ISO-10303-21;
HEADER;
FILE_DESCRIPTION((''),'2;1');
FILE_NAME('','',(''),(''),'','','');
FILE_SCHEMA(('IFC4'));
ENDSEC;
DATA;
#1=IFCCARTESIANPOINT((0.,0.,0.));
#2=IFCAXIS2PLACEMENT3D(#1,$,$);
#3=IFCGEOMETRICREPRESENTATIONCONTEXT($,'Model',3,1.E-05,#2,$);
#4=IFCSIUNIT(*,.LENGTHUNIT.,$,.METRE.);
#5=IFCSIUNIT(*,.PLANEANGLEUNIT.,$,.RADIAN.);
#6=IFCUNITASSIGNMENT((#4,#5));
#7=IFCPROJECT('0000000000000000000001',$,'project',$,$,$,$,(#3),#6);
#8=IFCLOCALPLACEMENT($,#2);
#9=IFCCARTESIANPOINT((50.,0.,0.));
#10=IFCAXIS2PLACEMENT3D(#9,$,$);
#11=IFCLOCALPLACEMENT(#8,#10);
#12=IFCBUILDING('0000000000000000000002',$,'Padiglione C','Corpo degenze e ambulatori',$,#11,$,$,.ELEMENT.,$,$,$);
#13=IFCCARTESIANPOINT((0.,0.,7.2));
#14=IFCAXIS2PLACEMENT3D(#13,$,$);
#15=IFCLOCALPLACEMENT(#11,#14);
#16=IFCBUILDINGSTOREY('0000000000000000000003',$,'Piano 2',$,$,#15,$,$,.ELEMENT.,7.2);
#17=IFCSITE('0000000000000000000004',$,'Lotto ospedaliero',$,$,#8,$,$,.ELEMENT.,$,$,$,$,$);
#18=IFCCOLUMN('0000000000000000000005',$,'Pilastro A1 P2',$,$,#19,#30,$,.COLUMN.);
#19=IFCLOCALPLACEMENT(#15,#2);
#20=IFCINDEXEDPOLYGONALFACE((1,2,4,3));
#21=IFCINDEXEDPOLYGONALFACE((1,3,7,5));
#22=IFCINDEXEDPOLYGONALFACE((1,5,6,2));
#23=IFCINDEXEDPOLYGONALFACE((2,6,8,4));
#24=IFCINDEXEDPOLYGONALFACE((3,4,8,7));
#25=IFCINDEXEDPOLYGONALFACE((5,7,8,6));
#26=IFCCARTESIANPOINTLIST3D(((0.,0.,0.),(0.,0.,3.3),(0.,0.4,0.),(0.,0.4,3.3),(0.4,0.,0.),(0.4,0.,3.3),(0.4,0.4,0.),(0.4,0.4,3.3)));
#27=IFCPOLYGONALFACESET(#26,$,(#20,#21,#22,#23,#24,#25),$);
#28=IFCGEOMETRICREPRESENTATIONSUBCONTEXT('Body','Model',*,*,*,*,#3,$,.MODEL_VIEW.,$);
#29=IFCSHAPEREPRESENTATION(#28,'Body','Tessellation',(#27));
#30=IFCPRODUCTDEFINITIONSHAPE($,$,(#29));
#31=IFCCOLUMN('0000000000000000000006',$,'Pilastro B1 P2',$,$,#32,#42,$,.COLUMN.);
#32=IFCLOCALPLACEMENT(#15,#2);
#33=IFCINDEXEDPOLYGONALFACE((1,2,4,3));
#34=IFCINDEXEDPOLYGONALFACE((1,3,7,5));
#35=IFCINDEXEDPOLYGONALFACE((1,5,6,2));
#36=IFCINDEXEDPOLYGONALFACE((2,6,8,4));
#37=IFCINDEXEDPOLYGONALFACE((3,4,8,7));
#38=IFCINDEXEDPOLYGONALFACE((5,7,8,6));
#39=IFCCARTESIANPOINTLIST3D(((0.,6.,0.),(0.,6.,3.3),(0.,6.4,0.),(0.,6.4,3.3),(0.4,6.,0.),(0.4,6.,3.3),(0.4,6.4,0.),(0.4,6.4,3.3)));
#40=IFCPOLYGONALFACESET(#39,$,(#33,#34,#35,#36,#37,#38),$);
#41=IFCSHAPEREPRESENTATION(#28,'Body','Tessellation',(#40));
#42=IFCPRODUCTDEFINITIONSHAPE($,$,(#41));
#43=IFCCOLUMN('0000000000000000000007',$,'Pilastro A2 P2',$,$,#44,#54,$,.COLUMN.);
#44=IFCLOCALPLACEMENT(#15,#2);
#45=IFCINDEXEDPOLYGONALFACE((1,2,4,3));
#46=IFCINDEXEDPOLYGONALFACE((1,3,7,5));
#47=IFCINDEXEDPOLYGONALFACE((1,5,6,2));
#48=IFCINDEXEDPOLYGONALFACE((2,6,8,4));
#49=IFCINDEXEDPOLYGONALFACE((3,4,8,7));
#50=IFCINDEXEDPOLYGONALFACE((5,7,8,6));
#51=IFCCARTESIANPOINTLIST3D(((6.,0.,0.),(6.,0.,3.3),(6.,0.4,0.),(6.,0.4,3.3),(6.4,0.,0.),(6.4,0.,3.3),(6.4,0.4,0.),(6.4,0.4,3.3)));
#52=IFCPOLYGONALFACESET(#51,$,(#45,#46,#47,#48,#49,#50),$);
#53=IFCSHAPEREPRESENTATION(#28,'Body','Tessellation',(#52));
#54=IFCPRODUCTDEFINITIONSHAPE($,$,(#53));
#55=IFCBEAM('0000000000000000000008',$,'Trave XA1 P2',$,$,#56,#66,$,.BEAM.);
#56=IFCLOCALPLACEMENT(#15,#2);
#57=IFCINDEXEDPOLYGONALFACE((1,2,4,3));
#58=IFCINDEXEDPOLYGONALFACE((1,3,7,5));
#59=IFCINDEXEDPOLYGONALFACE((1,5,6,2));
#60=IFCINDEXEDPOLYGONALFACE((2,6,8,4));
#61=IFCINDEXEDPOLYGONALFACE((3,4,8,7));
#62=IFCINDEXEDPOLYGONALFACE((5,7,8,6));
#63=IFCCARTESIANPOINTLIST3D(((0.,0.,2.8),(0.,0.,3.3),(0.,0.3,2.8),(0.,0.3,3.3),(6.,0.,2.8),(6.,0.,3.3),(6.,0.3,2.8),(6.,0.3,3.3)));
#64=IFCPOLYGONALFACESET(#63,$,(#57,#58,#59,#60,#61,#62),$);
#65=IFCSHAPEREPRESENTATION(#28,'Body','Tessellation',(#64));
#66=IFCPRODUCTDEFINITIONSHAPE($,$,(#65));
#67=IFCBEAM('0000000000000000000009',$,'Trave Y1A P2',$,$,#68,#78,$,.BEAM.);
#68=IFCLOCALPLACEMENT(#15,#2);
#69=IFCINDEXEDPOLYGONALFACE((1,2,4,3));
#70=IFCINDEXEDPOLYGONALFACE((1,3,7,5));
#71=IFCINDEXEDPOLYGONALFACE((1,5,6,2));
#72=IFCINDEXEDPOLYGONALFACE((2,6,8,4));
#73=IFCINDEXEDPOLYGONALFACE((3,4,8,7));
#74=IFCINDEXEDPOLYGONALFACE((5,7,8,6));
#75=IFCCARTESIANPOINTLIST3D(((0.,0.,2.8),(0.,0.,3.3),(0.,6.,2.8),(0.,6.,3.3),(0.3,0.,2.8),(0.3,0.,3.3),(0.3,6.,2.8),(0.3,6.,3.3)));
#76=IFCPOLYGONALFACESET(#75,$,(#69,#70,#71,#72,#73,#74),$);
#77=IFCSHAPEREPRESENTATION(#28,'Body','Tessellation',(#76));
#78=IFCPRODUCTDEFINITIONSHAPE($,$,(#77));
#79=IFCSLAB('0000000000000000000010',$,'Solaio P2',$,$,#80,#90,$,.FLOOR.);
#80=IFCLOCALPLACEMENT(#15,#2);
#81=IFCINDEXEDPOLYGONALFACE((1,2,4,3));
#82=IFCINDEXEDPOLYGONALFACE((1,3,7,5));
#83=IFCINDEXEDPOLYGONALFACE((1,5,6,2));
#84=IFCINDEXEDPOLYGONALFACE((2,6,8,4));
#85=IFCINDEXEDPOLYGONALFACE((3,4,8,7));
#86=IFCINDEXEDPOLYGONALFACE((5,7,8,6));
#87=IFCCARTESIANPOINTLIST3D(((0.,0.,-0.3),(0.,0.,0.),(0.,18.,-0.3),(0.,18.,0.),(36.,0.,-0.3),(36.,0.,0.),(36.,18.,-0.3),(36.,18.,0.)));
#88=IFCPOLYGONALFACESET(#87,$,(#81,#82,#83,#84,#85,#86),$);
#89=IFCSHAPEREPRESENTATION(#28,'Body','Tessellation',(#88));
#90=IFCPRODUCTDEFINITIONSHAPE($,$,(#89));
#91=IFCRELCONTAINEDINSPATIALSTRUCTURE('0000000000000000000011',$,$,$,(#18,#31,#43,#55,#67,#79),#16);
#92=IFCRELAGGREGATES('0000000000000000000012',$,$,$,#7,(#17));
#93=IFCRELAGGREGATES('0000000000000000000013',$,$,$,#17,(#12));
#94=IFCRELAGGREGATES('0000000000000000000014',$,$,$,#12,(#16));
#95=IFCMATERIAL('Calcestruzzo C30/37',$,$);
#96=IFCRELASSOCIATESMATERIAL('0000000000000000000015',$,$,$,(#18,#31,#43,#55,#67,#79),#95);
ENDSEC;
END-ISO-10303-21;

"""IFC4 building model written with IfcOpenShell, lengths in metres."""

from ifc_helpers import new_model, si_unit, frame, frame_2d, origin, place, context, subcontext, project, spatial, rectangle, extrude, material, element, save


model = new_model("IFC4")

# Units and contexts
model_context = context("Model", 3, precision=1e-05, world=origin())
body_context = subcontext(model_context, "Body", "Model", "MODEL_VIEW")
ifc_project = project(units=[si_unit("LENGTHUNIT", "METRE"), si_unit("PLANEANGLEUNIT", "RADIAN")], contexts=[model_context])

# Site, building, storey
site_placement = place(None, origin())
site = spatial("IfcSite", under=ifc_project, at=site_placement, Name="Lotto ospedaliero", CompositionType="ELEMENT")
building_placement = place(site_placement, frame((50.0, 0.0, 0.0)))
building = spatial("IfcBuilding", under=site, at=building_placement, Name="Padiglione C", Description="Corpo degenze e ambulatori", CompositionType="ELEMENT")
storey_placement = place(building_placement, frame((0.0, 0.0, 7.2)))
storey = spatial("IfcBuildingStorey", under=building, at=storey_placement, Name="Piano 2", CompositionType="ELEMENT", Elevation=7.2)

# Columns
ifc_material_1 = material(Name="Calcestruzzo C30/37")
for number, where, name in (
    (1, (0.0, 0.0, 0.0), "Pilastro A1 P2"),
    (2, (0.0, 6.0, 0.0), "Pilastro B1 P2"),
    (3, (6.0, 0.0, 0.0), "Pilastro A2 P2"),
):
    element("IfcColumn", number, at=place(storey_placement, frame(where)), inside=storey, material=ifc_material_1, Name=name, PredefinedType="COLUMN", context=body_context, shape_type="SweptSolid", body=[
        extrude(rectangle(XDim=0.4, YDim=0.4, at=frame_2d((0.2, 0.2))), origin(), (0.0, 0.0, 1.0), 3.3),
    ])

# Beams
beam_1_placement = place(storey_placement, frame((0.0, 0.0, 2.8)))
element("IfcBeam", 4, at=beam_1_placement, inside=storey, material=ifc_material_1, Name="Trave XA1 P2", PredefinedType="BEAM", context=body_context, shape_type="SweptSolid", body=[
    extrude(rectangle(XDim=6.0, YDim=0.3, at=frame_2d((3.0, 0.15))), origin(), (0.0, 0.0, 1.0), 0.5),
])
beam_2_placement = place(storey_placement, frame((0.0, 0.0, 2.8)))
element("IfcBeam", 5, at=beam_2_placement, inside=storey, material=ifc_material_1, Name="Trave Y1A P2", PredefinedType="BEAM", context=body_context, shape_type="SweptSolid", body=[
    extrude(rectangle(XDim=0.3, YDim=6.0, at=frame_2d((0.15, 3.0))), origin(), (0.0, 0.0, 1.0), 0.5),
])

# Slab
slab_placement = place(storey_placement, frame((0.0, 0.0, -0.3)))
element("IfcSlab", 6, at=slab_placement, inside=storey, material=ifc_material_1, Name="Solaio P2", PredefinedType="FLOOR", context=body_context, shape_type="SweptSolid", body=[
    extrude(rectangle(XDim=36.0, YDim=18.0, at=frame_2d((18.0, 9.0))), origin(), (0.0, 0.0, 1.0), 0.3),
])

save(model, "model.ifc")
